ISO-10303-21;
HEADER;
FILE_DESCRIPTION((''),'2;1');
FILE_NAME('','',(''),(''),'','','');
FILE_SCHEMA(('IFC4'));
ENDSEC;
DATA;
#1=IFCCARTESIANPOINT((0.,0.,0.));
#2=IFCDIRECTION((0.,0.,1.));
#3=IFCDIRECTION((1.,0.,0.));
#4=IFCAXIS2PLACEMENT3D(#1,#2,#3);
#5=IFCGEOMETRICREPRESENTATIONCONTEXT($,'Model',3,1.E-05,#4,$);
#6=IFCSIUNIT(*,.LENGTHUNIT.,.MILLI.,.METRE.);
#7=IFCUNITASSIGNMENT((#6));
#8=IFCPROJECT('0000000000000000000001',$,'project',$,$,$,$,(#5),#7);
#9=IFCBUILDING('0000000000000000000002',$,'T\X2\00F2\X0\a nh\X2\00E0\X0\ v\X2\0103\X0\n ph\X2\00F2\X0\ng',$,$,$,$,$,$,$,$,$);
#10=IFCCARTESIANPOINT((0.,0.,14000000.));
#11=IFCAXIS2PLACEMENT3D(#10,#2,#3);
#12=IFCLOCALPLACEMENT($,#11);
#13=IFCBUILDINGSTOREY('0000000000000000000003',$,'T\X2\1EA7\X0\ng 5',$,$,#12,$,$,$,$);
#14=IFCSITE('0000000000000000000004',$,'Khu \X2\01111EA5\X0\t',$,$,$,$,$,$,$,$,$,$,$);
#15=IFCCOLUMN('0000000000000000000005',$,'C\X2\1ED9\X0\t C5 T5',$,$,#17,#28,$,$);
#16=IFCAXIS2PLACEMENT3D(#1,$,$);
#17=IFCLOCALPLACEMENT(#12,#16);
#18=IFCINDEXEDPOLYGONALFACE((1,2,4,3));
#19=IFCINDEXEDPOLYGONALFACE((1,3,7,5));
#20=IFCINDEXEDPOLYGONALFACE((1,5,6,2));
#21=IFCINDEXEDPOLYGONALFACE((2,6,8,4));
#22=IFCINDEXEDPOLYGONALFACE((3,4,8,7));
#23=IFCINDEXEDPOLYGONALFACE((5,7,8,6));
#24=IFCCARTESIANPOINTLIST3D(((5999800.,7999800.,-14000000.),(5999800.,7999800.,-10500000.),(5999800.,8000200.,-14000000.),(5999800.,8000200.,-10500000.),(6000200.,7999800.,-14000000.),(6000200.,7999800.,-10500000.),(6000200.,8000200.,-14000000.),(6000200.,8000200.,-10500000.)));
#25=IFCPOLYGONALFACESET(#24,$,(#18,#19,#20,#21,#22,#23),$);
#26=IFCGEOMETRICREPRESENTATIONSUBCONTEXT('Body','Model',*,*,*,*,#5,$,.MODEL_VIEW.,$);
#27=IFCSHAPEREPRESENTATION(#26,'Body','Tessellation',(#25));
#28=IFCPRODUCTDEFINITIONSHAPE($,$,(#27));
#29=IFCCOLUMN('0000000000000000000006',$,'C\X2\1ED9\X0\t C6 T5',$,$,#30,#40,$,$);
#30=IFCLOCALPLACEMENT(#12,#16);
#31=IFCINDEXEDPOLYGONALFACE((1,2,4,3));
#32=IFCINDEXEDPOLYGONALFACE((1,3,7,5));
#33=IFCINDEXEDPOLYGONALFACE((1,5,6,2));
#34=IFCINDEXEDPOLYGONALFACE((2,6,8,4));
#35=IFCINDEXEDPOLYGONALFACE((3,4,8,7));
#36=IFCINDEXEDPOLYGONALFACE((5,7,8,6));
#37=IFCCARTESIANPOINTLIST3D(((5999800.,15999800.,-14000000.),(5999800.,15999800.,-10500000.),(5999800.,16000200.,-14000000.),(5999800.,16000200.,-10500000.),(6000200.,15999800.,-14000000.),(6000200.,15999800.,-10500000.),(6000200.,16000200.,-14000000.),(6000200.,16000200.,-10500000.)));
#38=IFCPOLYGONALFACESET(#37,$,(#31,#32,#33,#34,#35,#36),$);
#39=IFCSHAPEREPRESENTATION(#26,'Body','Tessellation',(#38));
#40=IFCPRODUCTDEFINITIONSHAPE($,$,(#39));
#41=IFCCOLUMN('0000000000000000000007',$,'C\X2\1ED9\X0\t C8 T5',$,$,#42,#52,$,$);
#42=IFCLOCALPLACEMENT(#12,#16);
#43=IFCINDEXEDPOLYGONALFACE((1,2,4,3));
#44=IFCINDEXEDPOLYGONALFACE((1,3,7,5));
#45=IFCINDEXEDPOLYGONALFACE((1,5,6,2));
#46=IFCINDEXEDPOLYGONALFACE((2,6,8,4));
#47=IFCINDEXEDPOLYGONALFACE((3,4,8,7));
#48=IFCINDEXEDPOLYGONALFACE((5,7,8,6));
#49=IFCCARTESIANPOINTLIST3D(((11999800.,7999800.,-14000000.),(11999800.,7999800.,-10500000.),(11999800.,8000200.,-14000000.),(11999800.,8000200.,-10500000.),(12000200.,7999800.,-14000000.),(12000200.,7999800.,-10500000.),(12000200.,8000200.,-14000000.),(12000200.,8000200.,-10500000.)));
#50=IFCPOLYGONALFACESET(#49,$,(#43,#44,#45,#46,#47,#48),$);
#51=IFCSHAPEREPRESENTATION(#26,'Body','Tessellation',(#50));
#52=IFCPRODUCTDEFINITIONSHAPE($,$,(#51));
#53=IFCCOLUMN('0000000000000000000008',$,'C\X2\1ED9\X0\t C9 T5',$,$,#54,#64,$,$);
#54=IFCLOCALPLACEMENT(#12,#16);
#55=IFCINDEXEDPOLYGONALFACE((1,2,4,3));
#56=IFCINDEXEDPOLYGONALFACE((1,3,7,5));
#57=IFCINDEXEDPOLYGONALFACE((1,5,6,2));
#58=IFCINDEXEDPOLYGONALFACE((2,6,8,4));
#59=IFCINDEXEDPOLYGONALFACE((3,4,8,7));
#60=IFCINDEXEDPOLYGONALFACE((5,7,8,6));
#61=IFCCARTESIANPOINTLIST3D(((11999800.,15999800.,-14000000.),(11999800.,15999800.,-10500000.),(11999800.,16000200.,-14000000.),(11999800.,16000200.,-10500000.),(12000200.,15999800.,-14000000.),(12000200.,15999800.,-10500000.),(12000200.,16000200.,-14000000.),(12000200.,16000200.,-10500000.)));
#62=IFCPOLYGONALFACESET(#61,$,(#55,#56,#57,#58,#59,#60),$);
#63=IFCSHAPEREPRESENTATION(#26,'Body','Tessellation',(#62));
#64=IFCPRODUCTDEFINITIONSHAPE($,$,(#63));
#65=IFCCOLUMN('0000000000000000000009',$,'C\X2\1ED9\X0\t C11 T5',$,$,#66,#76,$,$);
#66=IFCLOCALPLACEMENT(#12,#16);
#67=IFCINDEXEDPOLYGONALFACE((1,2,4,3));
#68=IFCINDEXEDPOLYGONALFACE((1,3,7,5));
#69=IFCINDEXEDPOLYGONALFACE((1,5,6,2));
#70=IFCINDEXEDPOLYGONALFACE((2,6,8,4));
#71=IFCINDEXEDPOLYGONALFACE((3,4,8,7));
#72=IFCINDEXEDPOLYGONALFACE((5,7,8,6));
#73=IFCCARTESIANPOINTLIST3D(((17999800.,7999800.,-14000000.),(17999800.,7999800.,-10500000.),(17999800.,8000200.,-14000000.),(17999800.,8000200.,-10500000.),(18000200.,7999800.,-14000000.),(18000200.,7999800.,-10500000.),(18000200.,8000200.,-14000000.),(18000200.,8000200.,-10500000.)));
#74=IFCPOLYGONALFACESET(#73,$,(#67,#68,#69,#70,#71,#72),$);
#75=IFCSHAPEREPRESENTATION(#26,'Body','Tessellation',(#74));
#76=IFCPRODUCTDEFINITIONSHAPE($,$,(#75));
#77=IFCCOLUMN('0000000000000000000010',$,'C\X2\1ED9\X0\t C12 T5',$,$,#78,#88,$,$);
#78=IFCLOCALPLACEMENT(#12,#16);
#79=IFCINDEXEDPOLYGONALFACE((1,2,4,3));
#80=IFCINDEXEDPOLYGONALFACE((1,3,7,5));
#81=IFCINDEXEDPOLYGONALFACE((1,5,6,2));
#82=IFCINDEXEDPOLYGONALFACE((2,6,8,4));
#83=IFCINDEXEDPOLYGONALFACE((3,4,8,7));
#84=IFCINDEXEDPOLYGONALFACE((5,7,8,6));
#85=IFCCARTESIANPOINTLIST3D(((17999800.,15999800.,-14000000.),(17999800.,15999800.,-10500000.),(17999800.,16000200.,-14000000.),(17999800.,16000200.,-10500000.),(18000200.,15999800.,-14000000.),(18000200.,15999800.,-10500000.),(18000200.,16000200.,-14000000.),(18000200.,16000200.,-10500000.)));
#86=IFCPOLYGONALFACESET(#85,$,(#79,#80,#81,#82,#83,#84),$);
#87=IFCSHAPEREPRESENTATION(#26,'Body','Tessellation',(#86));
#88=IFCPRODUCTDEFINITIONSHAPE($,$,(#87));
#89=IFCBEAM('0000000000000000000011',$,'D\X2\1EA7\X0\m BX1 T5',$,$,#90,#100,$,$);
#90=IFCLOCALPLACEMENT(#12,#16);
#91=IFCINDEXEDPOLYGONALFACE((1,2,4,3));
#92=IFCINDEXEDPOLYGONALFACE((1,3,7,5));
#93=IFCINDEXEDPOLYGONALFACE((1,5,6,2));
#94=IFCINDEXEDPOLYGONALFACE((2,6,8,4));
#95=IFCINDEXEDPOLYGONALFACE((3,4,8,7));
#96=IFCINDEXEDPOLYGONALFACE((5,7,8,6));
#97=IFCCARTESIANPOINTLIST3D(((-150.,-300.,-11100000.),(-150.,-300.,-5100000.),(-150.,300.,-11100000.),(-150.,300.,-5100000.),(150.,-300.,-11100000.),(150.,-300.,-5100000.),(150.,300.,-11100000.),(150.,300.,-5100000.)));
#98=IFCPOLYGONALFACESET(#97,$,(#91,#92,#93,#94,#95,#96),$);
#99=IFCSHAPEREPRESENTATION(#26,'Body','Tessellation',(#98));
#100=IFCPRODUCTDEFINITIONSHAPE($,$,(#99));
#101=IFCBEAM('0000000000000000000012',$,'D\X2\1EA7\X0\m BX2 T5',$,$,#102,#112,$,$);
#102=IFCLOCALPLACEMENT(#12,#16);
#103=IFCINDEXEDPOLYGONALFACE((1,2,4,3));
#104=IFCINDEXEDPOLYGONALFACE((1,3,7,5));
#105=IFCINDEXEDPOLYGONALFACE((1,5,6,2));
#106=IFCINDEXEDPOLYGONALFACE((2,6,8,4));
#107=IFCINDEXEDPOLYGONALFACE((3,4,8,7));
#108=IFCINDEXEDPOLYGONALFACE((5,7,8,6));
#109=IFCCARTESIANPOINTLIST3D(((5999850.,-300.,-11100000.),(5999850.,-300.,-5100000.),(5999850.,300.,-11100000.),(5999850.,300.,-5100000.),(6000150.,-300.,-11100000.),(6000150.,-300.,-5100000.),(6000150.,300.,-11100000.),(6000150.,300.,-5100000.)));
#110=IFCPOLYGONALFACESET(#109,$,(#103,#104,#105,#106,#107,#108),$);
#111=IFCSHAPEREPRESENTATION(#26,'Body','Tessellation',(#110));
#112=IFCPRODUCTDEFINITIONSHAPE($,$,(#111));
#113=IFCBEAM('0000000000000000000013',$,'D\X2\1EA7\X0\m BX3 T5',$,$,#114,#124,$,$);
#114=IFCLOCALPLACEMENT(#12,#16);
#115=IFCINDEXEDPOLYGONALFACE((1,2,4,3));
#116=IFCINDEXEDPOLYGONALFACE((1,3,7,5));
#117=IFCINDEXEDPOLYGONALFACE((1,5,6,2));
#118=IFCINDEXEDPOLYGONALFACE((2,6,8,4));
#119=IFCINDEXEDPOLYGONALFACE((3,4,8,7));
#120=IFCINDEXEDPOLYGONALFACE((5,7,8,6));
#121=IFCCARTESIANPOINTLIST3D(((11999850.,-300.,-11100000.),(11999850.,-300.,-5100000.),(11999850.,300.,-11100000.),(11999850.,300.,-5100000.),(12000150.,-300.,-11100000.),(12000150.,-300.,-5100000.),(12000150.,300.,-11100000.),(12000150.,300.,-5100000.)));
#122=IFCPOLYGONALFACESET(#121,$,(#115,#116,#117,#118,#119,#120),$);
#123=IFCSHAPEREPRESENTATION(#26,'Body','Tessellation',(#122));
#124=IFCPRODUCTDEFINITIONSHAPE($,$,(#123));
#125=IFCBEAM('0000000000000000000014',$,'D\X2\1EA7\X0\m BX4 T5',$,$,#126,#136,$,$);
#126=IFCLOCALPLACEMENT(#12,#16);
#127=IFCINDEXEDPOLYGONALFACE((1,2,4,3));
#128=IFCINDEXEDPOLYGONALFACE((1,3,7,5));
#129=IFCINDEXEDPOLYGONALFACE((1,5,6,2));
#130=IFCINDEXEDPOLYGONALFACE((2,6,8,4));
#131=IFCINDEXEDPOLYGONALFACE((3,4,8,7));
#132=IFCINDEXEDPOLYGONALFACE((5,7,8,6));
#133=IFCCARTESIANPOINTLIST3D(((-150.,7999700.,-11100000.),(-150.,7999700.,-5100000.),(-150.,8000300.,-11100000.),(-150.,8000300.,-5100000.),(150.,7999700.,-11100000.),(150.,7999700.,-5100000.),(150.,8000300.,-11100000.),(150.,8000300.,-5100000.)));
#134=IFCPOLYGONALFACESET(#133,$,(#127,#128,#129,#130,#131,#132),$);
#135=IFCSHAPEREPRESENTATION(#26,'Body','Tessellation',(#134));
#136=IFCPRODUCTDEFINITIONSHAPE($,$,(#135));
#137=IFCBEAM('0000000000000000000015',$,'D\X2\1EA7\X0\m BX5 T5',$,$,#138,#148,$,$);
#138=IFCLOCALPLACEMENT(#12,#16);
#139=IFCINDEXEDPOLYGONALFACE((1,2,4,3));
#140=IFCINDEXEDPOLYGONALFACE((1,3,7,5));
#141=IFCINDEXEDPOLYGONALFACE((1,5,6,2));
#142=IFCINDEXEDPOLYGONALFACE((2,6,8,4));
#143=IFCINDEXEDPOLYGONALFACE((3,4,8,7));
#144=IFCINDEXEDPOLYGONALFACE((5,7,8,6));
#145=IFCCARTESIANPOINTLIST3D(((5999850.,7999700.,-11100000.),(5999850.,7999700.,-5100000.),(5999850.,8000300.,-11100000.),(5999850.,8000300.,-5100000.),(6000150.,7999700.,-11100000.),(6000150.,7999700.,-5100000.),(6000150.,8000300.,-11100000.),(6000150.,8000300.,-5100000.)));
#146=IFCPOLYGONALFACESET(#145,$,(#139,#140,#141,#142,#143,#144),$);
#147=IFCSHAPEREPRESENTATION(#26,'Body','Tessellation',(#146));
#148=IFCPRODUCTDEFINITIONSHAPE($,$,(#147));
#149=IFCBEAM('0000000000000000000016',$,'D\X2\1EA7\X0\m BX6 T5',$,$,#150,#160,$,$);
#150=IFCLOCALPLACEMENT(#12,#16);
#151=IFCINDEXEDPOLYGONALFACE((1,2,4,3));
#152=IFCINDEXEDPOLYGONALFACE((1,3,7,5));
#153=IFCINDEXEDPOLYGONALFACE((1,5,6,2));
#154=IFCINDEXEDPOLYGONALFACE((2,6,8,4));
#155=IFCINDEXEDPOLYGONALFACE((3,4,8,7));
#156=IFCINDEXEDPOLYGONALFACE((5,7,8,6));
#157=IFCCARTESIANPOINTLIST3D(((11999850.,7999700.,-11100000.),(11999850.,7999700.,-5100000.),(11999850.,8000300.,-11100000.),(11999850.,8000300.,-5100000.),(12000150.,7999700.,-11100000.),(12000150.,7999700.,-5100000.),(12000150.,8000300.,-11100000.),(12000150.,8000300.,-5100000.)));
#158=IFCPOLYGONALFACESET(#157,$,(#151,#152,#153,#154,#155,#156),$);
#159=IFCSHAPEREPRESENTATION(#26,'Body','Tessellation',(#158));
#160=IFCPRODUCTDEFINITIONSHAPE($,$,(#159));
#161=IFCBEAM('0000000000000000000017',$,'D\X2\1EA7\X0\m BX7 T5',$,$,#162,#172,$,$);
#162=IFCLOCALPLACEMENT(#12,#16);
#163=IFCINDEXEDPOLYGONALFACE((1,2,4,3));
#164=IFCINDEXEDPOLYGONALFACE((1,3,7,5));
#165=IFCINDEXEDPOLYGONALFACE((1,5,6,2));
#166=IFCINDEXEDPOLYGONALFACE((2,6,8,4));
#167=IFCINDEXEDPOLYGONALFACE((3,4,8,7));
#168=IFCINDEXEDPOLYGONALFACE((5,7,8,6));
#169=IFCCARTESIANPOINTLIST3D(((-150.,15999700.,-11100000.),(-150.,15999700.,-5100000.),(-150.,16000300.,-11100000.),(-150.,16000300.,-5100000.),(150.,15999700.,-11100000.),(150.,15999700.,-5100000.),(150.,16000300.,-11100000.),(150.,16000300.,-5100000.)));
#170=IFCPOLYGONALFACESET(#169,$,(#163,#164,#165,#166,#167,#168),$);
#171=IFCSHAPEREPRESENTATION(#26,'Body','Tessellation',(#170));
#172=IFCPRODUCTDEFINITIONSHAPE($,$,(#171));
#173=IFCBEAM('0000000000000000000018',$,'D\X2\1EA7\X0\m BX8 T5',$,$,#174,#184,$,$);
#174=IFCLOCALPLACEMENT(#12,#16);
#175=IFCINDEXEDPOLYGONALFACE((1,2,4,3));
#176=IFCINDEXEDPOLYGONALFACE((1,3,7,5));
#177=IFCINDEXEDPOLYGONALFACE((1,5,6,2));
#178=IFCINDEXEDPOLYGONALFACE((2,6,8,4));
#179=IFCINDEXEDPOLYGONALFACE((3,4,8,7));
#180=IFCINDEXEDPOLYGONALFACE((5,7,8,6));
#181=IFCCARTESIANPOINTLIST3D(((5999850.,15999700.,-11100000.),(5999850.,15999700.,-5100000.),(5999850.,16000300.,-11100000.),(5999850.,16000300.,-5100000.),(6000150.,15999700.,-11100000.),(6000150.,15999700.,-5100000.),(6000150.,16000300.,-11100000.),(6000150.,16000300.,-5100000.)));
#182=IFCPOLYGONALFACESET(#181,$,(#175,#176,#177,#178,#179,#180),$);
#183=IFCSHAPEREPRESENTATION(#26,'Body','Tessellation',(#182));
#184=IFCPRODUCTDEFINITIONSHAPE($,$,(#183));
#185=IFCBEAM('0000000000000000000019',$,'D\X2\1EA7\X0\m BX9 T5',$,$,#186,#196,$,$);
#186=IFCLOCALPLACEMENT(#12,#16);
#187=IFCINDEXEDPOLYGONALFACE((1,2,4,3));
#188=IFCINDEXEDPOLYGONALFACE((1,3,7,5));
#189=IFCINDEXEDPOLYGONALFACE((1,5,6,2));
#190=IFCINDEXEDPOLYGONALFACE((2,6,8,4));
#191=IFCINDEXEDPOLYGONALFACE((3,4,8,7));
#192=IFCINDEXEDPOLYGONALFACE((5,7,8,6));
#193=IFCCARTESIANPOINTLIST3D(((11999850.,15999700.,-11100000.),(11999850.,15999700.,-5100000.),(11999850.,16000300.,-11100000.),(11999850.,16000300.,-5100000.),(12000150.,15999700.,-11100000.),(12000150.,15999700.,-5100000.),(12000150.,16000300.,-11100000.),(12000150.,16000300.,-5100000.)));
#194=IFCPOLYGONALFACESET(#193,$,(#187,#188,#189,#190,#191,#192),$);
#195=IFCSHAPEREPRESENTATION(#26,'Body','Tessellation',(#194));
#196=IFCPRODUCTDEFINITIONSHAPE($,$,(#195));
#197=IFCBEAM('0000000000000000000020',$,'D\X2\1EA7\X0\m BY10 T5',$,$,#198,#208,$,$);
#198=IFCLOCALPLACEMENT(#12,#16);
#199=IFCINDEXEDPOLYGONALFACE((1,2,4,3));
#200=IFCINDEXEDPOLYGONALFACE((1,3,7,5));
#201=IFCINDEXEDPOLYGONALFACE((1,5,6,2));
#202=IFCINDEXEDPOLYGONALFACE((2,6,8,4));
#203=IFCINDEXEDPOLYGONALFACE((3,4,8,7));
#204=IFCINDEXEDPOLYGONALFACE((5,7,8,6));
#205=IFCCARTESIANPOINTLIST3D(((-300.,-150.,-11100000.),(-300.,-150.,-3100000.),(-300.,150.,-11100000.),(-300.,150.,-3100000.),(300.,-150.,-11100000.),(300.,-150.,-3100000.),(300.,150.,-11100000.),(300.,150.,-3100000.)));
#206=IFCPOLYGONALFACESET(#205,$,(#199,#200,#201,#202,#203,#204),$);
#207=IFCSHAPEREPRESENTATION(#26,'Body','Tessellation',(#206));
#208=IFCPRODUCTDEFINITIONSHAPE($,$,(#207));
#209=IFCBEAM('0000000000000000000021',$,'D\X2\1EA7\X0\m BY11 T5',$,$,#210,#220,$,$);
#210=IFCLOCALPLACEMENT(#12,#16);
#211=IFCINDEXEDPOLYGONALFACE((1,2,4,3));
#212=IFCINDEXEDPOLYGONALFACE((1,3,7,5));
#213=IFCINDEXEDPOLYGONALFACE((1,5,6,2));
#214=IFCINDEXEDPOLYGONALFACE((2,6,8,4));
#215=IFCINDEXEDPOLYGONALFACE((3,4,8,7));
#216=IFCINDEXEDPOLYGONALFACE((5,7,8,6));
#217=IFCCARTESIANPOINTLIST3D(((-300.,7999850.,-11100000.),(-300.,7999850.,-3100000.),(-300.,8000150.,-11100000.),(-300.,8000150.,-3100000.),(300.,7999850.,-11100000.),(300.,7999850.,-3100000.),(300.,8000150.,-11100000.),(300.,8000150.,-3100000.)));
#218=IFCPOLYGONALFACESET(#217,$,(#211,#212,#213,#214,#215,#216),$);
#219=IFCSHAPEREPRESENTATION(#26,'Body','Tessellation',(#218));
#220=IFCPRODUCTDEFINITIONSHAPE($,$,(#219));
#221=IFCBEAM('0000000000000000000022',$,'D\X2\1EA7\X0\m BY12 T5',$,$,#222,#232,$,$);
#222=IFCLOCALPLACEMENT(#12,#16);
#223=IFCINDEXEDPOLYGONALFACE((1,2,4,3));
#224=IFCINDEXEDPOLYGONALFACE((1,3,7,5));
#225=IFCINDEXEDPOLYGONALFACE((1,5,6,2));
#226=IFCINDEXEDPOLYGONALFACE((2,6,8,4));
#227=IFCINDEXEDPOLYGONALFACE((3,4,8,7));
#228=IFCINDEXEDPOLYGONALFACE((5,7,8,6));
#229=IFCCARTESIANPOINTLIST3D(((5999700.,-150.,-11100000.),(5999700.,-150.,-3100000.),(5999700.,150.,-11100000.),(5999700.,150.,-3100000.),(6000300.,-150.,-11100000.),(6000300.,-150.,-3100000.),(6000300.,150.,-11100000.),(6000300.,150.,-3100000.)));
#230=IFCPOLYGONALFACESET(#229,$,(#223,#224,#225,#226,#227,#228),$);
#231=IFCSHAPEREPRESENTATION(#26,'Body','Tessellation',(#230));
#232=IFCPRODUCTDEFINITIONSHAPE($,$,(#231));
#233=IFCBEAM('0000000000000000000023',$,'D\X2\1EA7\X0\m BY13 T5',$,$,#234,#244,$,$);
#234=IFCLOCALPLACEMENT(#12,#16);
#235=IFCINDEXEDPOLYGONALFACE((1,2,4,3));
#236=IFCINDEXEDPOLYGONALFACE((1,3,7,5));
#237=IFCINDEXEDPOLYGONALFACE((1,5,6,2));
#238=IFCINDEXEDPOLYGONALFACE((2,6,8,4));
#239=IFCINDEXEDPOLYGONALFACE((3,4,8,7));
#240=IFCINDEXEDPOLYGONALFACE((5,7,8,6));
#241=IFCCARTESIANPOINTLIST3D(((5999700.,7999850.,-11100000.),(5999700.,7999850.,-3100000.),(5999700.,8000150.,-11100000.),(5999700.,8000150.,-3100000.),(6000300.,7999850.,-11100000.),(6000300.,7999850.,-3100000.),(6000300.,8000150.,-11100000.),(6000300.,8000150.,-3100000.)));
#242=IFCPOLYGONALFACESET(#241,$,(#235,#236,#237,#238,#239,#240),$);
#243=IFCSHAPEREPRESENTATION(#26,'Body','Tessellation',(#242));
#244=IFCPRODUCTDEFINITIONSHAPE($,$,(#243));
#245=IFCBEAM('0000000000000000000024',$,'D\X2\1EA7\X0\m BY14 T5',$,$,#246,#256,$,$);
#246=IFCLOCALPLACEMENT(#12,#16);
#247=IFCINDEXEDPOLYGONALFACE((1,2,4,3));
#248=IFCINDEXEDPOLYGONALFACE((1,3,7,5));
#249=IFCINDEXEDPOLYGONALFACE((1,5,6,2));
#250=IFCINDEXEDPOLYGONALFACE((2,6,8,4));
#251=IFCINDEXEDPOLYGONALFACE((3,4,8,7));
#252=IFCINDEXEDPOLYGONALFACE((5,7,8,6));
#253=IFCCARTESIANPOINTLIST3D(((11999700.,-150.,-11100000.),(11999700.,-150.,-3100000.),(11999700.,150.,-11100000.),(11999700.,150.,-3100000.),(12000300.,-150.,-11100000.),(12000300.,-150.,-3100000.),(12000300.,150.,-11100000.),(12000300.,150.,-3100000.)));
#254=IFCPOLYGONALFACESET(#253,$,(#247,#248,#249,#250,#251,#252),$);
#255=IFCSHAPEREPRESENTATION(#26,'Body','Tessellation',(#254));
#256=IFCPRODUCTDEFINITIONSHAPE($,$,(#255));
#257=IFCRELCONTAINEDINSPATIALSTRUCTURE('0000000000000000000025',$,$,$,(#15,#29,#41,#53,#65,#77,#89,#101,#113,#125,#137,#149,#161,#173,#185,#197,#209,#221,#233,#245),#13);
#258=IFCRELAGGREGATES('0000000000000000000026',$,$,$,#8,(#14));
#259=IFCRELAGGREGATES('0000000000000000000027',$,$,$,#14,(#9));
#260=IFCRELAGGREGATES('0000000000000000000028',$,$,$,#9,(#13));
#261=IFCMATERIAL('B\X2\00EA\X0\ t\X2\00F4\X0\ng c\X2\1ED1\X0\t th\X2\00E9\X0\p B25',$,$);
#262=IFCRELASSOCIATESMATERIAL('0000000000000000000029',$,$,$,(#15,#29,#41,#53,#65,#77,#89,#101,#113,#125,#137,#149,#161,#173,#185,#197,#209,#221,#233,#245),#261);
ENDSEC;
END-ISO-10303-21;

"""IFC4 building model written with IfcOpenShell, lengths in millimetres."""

from ifc_helpers import new_model, entity, si_unit, frame, origin_with_axes, place, context, subcontext, project, spatial, extrude, material, element, save


model = new_model("IFC4")

# Units and contexts
model_context = context("Model", 3, precision=1e-05, world=origin_with_axes())
body_context = subcontext(model_context, "Body", "Model", "MODEL_VIEW")
ifc_project = project(units=[si_unit("LENGTHUNIT", "METRE", prefix="MILLI")], contexts=[model_context])

# Site, building, storey
site = spatial("IfcSite", under=ifc_project, Name="Khu đất")
building = spatial("IfcBuilding", under=site, Name="Tòa nhà văn phòng")
storey_placement = place(None, frame((0.0, 0.0, 14000000.0), z_axis=(0.0, 0.0, 1.0), x_axis=(1.0, 0.0, 0.0)))
storey = spatial("IfcBuildingStorey", under=building, at=storey_placement, Name="Tầng 5")

# Columns
ifc_material_1 = material(Name="Bê tông cốt thép B25")
for number, where, z_axis, x_axis, name in (
    (1, (6000000.0, 8000000.0, -14000000.0), (0.0, 0.0, 1.0), (1.0, 0.0, 0.0), "Cột C5 T5"),
    (2, (6000000.0, 16000000.0, -14000000.0), (0.0, 0.0, 1.0), (1.0, 0.0, 0.0), "Cột C6 T5"),
    (3, (12000000.0, 8000000.0, -14000000.0), (0.0, 0.0, 1.0), (1.0, 0.0, 0.0), "Cột C8 T5"),
    (4, (12000000.0, 16000000.0, -14000000.0), (0.0, 0.0, 1.0), (1.0, 0.0, 0.0), "Cột C9 T5"),
    (5, (18000000.0, 8000000.0, -14000000.0), (0.0, 0.0, 1.0), (1.0, 0.0, 0.0), "Cột C11 T5"),
    (6, (18000000.0, 16000000.0, -14000000.0), (0.0, 0.0, 1.0), (1.0, 0.0, 0.0), "Cột C12 T5"),
):
    element("IfcColumn", number, at=place(storey_placement, frame(where, z_axis=z_axis, x_axis=x_axis)), inside=storey, material=ifc_material_1, Name=name, context=body_context, shape_type="SweptSolid", body=[
        extrude(entity("IfcRectangleProfileDef", None, None, None, 400.0, 400.0), origin_with_axes(), (0.0, 0.0, 1.0), 3500000.0),
    ])

# Beams
for number, where, z_axis, x_axis, name in (
    (7, (0.0, 0.0, -11100000.0), (0.0, 0.0, 1.0), (1.0, 0.0, 0.0), "Dầm BX1 T5"),
    (8, (6000000.0, 0.0, -11100000.0), (0.0, 0.0, 1.0), (1.0, 0.0, 0.0), "Dầm BX2 T5"),
    (9, (12000000.0, 0.0, -11100000.0), (0.0, 0.0, 1.0), (1.0, 0.0, 0.0), "Dầm BX3 T5"),
    (10, (0.0, 8000000.0, -11100000.0), (0.0, 0.0, 1.0), (1.0, 0.0, 0.0), "Dầm BX4 T5"),
    (11, (6000000.0, 8000000.0, -11100000.0), (0.0, 0.0, 1.0), (1.0, 0.0, 0.0), "Dầm BX5 T5"),
    (12, (12000000.0, 8000000.0, -11100000.0), (0.0, 0.0, 1.0), (1.0, 0.0, 0.0), "Dầm BX6 T5"),
    (13, (0.0, 16000000.0, -11100000.0), (0.0, 0.0, 1.0), (1.0, 0.0, 0.0), "Dầm BX7 T5"),
    (14, (6000000.0, 16000000.0, -11100000.0), (0.0, 0.0, 1.0), (1.0, 0.0, 0.0), "Dầm BX8 T5"),
    (15, (12000000.0, 16000000.0, -11100000.0), (0.0, 0.0, 1.0), (1.0, 0.0, 0.0), "Dầm BX9 T5"),
):
    element("IfcBeam", number, at=place(storey_placement, frame(where, z_axis=z_axis, x_axis=x_axis)), inside=storey, material=ifc_material_1, Name=name, context=body_context, shape_type="SweptSolid", body=[
        extrude(entity("IfcRectangleProfileDef", None, None, None, 300.0, 600.0), origin_with_axes(), (0.0, 0.0, 1.0), 6000000.0),
    ])
for number, where, z_axis, x_axis, name in (
    (16, (0.0, 0.0, -11100000.0), (0.0, 0.0, 1.0), (0.0, 1.0, 0.0), "Dầm BY10 T5"),
    (17, (0.0, 8000000.0, -11100000.0), (0.0, 0.0, 1.0), (0.0, 1.0, 0.0), "Dầm BY11 T5"),
    (18, (6000000.0, 0.0, -11100000.0), (0.0, 0.0, 1.0), (0.0, 1.0, 0.0), "Dầm BY12 T5"),
    (19, (6000000.0, 8000000.0, -11100000.0), (0.0, 0.0, 1.0), (0.0, 1.0, 0.0), "Dầm BY13 T5"),
    (20, (12000000.0, 0.0, -11100000.0), (0.0, 0.0, 1.0), (0.0, 1.0, 0.0), "Dầm BY14 T5"),
):
    element("IfcBeam", number, at=place(storey_placement, frame(where, z_axis=z_axis, x_axis=x_axis)), inside=storey, material=ifc_material_1, Name=name, context=body_context, shape_type="SweptSolid", body=[
        extrude(entity("IfcRectangleProfileDef", None, None, None, 300.0, 600.0), origin_with_axes(), (0.0, 0.0, 1.0), 8000000.0),
    ])

save(model, "model.ifc")
